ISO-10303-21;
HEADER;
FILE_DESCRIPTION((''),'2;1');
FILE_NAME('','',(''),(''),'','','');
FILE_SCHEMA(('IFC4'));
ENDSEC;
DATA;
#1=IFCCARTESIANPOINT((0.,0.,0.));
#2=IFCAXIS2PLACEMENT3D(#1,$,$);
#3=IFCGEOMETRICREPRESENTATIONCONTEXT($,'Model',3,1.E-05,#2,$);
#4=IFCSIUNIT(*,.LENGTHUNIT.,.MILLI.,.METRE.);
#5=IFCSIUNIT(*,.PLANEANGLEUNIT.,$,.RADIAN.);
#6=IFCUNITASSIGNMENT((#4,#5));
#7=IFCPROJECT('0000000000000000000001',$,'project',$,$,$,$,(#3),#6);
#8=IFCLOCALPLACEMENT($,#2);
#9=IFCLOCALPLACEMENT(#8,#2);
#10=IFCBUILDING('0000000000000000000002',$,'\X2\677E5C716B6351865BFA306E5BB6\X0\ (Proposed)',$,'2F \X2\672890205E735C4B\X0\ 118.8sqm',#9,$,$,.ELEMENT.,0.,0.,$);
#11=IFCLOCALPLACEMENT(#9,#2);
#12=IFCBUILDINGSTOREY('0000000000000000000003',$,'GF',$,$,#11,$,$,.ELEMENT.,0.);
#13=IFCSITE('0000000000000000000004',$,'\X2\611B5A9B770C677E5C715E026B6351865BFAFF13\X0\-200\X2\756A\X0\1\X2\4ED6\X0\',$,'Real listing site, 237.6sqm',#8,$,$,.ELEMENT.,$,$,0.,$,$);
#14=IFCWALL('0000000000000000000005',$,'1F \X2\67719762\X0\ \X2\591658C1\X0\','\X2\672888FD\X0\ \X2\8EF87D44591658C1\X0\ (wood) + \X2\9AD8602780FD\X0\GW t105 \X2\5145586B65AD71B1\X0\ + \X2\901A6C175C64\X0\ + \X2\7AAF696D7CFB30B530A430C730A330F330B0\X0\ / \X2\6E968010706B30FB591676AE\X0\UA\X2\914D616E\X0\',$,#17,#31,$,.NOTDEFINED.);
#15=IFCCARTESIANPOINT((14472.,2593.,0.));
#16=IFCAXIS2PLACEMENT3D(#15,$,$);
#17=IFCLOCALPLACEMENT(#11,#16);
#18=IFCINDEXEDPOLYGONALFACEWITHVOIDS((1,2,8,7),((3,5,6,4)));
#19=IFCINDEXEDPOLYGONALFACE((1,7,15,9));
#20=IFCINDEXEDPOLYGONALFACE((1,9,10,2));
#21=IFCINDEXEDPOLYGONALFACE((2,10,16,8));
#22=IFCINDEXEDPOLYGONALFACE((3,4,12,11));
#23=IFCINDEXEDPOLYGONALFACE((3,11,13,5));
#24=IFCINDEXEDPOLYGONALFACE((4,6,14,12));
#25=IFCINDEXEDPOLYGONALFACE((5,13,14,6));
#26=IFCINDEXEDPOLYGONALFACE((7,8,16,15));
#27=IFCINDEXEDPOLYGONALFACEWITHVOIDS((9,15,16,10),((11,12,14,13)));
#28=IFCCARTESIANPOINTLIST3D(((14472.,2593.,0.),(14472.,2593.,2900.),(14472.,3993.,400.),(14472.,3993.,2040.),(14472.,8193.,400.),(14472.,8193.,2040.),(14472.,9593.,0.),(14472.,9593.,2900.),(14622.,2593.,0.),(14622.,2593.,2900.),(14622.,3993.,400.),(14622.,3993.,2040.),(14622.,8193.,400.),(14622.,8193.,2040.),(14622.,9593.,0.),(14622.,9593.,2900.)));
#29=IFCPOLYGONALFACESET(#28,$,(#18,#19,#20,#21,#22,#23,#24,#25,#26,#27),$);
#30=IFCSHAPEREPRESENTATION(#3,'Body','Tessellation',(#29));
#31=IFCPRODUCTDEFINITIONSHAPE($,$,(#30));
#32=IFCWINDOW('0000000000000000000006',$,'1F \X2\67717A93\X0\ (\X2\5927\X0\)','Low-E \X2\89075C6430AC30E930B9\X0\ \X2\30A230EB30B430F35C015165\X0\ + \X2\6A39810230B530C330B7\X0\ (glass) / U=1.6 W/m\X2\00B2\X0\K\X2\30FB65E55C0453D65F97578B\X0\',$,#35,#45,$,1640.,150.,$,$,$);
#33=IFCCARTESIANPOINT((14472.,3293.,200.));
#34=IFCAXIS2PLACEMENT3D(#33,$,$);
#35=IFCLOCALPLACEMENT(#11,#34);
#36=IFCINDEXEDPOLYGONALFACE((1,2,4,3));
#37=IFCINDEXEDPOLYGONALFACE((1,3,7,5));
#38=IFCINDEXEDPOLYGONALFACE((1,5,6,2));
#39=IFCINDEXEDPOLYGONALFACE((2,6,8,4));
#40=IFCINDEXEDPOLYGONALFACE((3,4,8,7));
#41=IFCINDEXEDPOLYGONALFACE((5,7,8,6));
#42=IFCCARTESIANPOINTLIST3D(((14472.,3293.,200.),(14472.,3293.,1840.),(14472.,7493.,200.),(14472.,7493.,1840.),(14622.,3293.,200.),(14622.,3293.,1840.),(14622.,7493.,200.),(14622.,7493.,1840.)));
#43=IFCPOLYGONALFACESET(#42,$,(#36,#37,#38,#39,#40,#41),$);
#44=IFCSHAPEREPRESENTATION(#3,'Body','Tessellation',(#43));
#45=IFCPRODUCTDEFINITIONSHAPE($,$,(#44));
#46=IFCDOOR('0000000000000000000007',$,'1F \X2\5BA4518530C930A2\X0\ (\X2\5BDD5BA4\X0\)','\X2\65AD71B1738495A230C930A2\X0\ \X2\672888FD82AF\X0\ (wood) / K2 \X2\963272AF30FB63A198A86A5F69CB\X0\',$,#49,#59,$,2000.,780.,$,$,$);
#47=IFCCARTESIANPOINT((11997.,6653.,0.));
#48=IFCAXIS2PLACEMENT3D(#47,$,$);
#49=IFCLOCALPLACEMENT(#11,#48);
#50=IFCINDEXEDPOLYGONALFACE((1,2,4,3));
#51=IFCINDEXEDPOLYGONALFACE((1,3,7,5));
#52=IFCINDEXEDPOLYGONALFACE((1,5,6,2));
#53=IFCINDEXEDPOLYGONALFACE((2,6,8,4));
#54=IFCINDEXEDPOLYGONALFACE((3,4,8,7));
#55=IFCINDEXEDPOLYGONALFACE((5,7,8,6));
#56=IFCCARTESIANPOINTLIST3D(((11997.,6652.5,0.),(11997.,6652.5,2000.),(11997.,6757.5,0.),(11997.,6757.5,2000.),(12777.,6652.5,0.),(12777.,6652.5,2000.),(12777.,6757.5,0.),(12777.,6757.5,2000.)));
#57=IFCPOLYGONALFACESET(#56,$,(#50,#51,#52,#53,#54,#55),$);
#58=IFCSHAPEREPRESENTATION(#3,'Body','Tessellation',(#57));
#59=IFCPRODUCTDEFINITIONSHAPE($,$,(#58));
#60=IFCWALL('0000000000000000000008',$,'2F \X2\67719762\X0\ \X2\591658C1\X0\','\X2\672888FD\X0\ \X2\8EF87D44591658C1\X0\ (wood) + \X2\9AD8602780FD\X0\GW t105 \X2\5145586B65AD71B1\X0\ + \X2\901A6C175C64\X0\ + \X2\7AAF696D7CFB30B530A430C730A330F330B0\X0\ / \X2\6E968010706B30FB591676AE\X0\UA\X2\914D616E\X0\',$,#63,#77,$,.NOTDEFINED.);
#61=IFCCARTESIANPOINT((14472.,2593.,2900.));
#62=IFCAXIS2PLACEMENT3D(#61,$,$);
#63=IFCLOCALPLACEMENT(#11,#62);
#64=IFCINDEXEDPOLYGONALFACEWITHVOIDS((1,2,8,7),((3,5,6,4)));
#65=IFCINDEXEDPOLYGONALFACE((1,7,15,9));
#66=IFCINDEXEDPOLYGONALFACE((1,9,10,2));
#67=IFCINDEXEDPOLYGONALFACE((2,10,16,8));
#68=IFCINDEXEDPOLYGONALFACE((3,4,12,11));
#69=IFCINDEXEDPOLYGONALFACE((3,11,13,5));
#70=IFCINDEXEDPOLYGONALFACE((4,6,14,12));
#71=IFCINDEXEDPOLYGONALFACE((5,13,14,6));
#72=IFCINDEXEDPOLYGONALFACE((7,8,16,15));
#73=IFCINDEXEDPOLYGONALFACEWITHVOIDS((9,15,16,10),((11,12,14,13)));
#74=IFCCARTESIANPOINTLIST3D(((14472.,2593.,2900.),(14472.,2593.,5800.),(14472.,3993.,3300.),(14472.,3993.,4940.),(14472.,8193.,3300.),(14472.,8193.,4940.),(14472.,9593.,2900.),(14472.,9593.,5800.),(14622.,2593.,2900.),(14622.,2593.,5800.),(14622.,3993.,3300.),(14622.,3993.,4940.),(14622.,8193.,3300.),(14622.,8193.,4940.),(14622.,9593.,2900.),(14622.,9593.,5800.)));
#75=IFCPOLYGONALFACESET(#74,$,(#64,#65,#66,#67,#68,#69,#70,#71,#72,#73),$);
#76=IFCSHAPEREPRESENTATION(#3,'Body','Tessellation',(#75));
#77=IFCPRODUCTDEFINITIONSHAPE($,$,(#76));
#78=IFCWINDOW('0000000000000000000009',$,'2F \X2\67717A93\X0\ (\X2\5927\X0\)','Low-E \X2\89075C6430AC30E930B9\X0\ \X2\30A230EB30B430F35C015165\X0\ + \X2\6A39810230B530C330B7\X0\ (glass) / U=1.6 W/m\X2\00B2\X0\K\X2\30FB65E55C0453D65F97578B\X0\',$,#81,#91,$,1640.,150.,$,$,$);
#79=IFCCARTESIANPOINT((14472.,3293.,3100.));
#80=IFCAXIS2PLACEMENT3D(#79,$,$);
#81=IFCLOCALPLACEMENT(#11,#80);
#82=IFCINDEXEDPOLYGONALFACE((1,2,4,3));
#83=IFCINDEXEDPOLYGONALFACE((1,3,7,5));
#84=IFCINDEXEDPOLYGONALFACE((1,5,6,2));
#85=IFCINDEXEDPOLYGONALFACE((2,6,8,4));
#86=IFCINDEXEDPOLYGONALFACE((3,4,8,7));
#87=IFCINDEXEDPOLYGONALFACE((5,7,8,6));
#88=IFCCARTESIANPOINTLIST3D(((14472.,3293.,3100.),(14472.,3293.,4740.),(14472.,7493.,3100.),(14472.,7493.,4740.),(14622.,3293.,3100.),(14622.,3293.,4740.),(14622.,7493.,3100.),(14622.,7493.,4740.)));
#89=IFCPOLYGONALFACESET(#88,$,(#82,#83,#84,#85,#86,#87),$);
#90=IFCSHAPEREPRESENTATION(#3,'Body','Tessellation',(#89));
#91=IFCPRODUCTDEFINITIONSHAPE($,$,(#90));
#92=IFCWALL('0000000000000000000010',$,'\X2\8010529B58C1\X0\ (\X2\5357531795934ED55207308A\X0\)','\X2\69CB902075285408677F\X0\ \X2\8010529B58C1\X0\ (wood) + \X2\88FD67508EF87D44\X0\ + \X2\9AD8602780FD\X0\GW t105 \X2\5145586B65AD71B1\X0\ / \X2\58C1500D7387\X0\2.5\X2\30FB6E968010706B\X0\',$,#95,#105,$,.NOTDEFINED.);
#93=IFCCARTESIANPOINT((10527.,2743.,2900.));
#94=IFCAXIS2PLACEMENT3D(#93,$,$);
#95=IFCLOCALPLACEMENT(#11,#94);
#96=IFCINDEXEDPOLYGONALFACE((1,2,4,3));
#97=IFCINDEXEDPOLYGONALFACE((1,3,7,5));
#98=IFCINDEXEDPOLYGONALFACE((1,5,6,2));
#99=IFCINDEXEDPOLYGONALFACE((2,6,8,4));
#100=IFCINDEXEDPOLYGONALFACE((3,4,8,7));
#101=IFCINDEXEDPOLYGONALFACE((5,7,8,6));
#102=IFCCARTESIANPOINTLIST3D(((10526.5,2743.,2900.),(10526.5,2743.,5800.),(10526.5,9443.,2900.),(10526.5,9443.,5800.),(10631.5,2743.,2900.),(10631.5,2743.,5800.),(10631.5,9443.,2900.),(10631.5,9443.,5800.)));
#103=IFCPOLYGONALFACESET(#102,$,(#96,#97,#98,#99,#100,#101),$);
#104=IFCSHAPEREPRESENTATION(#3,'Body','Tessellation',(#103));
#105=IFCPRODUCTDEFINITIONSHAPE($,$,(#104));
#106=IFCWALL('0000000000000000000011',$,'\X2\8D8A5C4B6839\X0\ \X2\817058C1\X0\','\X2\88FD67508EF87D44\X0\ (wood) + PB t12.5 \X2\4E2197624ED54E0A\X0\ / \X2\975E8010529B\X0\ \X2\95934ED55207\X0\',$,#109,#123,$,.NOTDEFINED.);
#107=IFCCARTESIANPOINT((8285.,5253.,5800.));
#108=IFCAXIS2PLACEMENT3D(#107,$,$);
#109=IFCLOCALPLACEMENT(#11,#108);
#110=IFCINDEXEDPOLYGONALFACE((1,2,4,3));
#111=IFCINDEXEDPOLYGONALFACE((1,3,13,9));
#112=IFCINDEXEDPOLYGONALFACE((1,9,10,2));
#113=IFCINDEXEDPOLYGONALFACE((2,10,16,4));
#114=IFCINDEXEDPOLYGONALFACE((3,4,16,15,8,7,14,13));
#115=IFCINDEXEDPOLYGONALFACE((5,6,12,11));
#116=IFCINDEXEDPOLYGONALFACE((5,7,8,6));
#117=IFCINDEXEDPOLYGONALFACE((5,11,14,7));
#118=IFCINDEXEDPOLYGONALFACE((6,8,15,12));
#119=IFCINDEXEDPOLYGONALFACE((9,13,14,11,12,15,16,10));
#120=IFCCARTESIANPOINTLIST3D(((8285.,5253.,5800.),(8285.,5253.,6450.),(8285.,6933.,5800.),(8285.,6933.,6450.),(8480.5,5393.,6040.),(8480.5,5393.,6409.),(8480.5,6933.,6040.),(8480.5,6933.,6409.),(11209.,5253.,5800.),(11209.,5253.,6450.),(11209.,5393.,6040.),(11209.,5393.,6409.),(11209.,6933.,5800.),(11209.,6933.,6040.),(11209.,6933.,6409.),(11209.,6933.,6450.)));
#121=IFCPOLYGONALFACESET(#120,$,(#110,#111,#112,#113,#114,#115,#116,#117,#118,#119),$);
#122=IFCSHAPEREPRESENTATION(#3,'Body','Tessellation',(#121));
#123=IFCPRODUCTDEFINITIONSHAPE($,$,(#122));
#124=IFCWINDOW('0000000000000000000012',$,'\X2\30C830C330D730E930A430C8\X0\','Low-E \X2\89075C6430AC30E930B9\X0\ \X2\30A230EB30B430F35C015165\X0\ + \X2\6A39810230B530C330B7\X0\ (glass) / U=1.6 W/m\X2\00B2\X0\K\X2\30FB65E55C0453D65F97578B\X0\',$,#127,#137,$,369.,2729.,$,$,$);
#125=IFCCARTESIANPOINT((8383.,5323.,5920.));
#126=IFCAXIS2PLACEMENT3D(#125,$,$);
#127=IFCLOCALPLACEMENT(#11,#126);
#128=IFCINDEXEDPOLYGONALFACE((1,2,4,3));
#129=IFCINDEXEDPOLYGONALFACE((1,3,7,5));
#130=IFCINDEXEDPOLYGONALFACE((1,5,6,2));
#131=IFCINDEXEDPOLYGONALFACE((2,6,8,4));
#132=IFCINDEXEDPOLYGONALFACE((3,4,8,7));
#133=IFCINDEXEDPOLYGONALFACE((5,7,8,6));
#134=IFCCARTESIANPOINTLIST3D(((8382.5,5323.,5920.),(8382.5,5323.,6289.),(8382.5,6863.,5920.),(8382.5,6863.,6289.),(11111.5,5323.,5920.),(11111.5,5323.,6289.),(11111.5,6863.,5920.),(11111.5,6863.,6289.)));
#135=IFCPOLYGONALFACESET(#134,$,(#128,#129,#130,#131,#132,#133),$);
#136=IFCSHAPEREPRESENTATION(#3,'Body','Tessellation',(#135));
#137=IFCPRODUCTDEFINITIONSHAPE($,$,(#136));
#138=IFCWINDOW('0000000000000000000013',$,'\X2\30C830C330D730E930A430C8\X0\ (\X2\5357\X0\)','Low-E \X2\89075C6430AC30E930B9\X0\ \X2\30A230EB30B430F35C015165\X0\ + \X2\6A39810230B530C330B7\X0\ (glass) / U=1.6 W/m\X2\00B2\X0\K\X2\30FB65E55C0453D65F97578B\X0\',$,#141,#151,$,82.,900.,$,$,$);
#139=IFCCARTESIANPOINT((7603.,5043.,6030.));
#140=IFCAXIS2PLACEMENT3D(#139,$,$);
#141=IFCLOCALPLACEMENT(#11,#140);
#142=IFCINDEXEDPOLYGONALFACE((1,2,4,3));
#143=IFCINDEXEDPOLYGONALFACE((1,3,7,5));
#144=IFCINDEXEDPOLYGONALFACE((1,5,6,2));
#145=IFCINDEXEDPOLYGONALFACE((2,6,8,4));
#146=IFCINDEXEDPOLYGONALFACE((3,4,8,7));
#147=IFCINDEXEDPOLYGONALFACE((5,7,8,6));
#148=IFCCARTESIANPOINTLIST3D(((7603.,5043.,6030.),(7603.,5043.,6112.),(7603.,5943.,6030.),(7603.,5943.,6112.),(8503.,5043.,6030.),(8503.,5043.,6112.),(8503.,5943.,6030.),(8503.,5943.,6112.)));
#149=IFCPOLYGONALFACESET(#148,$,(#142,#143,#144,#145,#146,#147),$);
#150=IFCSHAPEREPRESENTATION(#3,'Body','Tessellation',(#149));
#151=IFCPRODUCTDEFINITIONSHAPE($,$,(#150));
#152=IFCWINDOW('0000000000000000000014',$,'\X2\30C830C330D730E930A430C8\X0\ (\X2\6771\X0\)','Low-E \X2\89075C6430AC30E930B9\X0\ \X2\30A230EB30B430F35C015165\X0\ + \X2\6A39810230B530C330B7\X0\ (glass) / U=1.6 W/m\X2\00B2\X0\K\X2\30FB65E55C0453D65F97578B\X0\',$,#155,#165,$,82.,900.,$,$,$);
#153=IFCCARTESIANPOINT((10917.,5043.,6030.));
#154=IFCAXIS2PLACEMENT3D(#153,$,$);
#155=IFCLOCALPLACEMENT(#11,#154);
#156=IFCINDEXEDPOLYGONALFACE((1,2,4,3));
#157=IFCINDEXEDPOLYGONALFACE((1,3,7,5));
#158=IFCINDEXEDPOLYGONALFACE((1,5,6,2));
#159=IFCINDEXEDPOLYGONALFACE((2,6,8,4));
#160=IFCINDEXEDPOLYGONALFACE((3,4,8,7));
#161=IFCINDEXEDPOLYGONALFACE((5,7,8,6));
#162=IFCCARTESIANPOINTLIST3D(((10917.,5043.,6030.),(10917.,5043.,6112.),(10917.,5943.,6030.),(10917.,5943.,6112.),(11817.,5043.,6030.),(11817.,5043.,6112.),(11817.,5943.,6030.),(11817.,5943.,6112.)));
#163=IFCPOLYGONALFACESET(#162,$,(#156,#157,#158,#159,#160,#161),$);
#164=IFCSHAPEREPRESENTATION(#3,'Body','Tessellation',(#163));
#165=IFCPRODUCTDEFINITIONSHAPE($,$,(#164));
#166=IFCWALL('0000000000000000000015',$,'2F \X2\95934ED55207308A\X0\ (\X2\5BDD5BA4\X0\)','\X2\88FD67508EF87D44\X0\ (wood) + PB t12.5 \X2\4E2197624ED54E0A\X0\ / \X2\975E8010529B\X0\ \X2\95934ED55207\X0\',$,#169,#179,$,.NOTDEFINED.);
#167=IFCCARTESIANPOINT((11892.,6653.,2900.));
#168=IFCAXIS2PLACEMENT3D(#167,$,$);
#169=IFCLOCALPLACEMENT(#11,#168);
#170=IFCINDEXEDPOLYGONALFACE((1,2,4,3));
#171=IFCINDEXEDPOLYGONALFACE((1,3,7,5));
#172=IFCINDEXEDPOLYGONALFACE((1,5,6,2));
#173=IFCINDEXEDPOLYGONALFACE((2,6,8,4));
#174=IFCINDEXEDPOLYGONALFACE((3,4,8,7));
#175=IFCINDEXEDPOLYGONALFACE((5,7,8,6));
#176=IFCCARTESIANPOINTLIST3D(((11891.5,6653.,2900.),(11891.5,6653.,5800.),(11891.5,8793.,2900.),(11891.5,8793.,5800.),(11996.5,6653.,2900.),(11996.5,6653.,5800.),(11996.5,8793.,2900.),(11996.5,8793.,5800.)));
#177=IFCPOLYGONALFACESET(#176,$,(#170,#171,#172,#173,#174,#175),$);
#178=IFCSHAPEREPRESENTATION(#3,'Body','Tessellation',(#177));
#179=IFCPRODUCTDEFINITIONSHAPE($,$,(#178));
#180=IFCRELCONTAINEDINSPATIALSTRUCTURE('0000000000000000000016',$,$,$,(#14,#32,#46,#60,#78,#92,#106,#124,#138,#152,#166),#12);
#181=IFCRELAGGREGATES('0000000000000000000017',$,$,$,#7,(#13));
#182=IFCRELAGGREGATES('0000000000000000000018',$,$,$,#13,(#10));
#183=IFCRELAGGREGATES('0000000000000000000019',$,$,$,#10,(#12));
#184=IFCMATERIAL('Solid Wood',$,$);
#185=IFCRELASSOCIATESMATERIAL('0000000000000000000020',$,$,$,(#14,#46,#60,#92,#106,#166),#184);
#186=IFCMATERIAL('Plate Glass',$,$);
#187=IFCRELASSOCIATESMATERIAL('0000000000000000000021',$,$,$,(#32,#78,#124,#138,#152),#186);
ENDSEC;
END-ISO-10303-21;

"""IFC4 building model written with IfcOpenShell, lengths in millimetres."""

from ifc_helpers import new_model, si_unit, frame, frame_2d, origin, place, context, project, spatial, rectangle, extrude, material, element, fill, save


model = new_model("IFC4")

# Units and contexts
model_context = context("Model", 3, precision=1e-05, world=origin())
ifc_project = project(units=[si_unit("LENGTHUNIT", "METRE", prefix="MILLI"), si_unit("PLANEANGLEUNIT", "RADIAN")], contexts=[model_context])

# Site, building, storey
site_placement = place(None, origin())
site = spatial("IfcSite", under=ifc_project, at=site_placement, Name="愛媛県松山市正円寺３-200番1他", ObjectType="Real listing site, 237.6sqm", CompositionType="ELEMENT", RefElevation=0.0)
building_placement = place(site_placement, origin())
building = spatial("IfcBuilding", under=site, at=building_placement, Name="松山正円寺の家 (Proposed)", ObjectType="2F 木造平屋 118.8sqm", CompositionType="ELEMENT", ElevationOfRefHeight=0.0, ElevationOfTerrain=0.0)
storey_placement = place(building_placement, origin())
storey = spatial("IfcBuildingStorey", under=building, at=storey_placement, Name="GF", CompositionType="ELEMENT", Elevation=0.0)

# Wall, opening, window
ifc_material_1 = material(Name="Solid Wood")
wall_1_placement = place(storey_placement, frame((14472.0, 2593.0, 0.0)))
wall_1 = element("IfcWall", 1, at=wall_1_placement, inside=storey, material=ifc_material_1, Name="1F 東面 外壁", Description="木製 軸組外壁 (wood) + 高性能GW t105 充填断熱 + 通気層 + 窯業系サイディング / 準耐火・外皮UA配慮", PredefinedType="NOTDEFINED", context=model_context, shape_type="SweptSolid", body=[
    extrude(rectangle(XDim=150.0, YDim=7000.0, at=frame_2d((75.0, 3500.0))), frame((14472.0, 2593.0, 0.0)), (0.0, 0.0, 1.0), 2900.0),
])
opening_1_placement = place(storey_placement, frame((14472.0, 3293.0, 200.0)))
opening_1 = element("IfcOpeningElement", 2, at=opening_1_placement, cuts=wall_1, PredefinedType="NOTDEFINED", context=model_context, shape_type="SweptSolid", body=[
    extrude(rectangle(XDim=150.0, YDim=4200.0, at=frame_2d((75.0, 2100.0))), frame((14472.0, 3293.0, 200.0)), (0.0, 0.0, 1.0), 1640.0),
])
ifc_material_2 = material(Name="Plate Glass")
window_1_placement = place(storey_placement, frame((14472.0, 3293.0, 200.0)))
window_1 = element("IfcWindow", 3, at=window_1_placement, inside=storey, material=ifc_material_2, Name="1F 東窓 (大)", Description="Low-E 複層ガラス アルゴン封入 + 樹脂サッシ (glass) / U=1.6 W/m²K・日射取得型", OverallHeight=1640.0, OverallWidth=150.0, context=model_context, shape_type="SweptSolid", body=[
    extrude(rectangle(XDim=150.0, YDim=4200.0, at=frame_2d((75.0, 2100.0))), frame((14472.0, 3293.0, 200.0)), (0.0, 0.0, 1.0), 1640.0),
])
fill(opening_1, window_1)

# Door
door_1_placement = place(storey_placement, frame((11997.0, 6653.0, 0.0)))
element("IfcDoor", 4, at=door_1_placement, inside=storey, material=ifc_material_1, Name="1F 室内ドア (寝室)", Description="断熱玄関ドア 木製芯 (wood) / K2 防犯・採風機構", OverallHeight=2000.0, OverallWidth=780.0, context=model_context, shape_type="SweptSolid", body=[
    extrude(rectangle(XDim=780.0, YDim=105.0, at=frame_2d((390.0, 52.0))), frame((11997.0, 6653.0, 0.0)), (0.0, 0.0, 1.0), 2000.0),
])

# Wall, opening, window
wall_2_placement = place(storey_placement, frame((14472.0, 2593.0, 2900.0)))
wall_2 = element("IfcWall", 5, at=wall_2_placement, inside=storey, material=ifc_material_1, Name="2F 東面 外壁", Description="木製 軸組外壁 (wood) + 高性能GW t105 充填断熱 + 通気層 + 窯業系サイディング / 準耐火・外皮UA配慮", PredefinedType="NOTDEFINED", context=model_context, shape_type="SweptSolid", body=[
    extrude(rectangle(XDim=150.0, YDim=7000.0, at=frame_2d((75.0, 3500.0))), frame((14472.0, 2593.0, 2900.0)), (0.0, 0.0, 1.0), 2900.0),
])
opening_2_placement = place(storey_placement, frame((14472.0, 3293.0, 3100.0)))
opening_2 = element("IfcOpeningElement", 6, at=opening_2_placement, cuts=wall_2, PredefinedType="NOTDEFINED", context=model_context, shape_type="SweptSolid", body=[
    extrude(rectangle(XDim=150.0, YDim=4200.0, at=frame_2d((75.0, 2100.0))), frame((14472.0, 3293.0, 3100.0)), (0.0, 0.0, 1.0), 1640.0),
])
window_2_placement = place(storey_placement, frame((14472.0, 3293.0, 3100.0)))
window_2 = element("IfcWindow", 7, at=window_2_placement, inside=storey, material=ifc_material_2, Name="2F 東窓 (大)", Description="Low-E 複層ガラス アルゴン封入 + 樹脂サッシ (glass) / U=1.6 W/m²K・日射取得型", OverallHeight=1640.0, OverallWidth=150.0, context=model_context, shape_type="SweptSolid", body=[
    extrude(rectangle(XDim=150.0, YDim=4200.0, at=frame_2d((75.0, 2100.0))), frame((14472.0, 3293.0, 3100.0)), (0.0, 0.0, 1.0), 1640.0),
])
fill(opening_2, window_2)

# Wall
wall_3_placement = place(storey_placement, frame((10527.0, 2743.0, 2900.0)))
element("IfcWall", 8, at=wall_3_placement, inside=storey, material=ifc_material_1, Name="耐力壁 (南北間仕切り)", Description="構造用合板 耐力壁 (wood) + 製材軸組 + 高性能GW t105 充填断熱 / 壁倍率2.5・準耐火", PredefinedType="NOTDEFINED", context=model_context, shape_type="SweptSolid", body=[
    extrude(rectangle(XDim=105.0, YDim=6700.0, at=frame_2d((52.0, 3350.0))), frame((10527.0, 2743.0, 2900.0)), (0.0, 0.0, 1.0), 2900.0),
])

# Wall, openings, windows
wall_4_placement = place(storey_placement, frame((8285.0, 5253.0, 5800.0)))
wall_4 = element("IfcWall", 9, at=wall_4_placement, inside=storey, material=ifc_material_1, Name="越屋根 腰壁", Description="製材軸組 (wood) + PB t12.5 両面仕上 / 非耐力 間仕切", PredefinedType="NOTDEFINED", context=model_context, shape_type="SweptSolid", body=[
    extrude(rectangle(XDim=2924.0, YDim=1680.0, at=frame_2d((1462.0, 840.0))), frame((8285.0, 5253.0, 5800.0)), (0.0, 0.0, 1.0), 650.0),
])
opening_3_placement = place(storey_placement, frame((8383.0, 5323.0, 5920.0)))
opening_3 = element("IfcOpeningElement", 10, at=opening_3_placement, cuts=wall_4, PredefinedType="NOTDEFINED", context=model_context, shape_type="SweptSolid", body=[
    extrude(rectangle(XDim=2729.0, YDim=1540.0, at=frame_2d((1364.0, 770.0))), frame((8383.0, 5323.0, 5920.0)), (0.0, 0.0, 1.0), 369.0),
])
opening_4_placement = place(storey_placement, frame((7603.0, 5043.0, 6030.0)))
opening_4 = element("IfcOpeningElement", 11, at=opening_4_placement, cuts=wall_4, PredefinedType="NOTDEFINED", context=model_context, shape_type="SweptSolid", body=[
    extrude(rectangle(XDim=900.0, YDim=900.0, at=frame_2d((450.0, 450.0))), frame((7603.0, 5043.0, 6030.0)), (0.0, 0.0, 1.0), 82.0),
])
opening_5_placement = place(storey_placement, frame((10917.0, 5043.0, 6030.0)))
opening_5 = element("IfcOpeningElement", 12, at=opening_5_placement, cuts=wall_4, PredefinedType="NOTDEFINED", context=model_context, shape_type="SweptSolid", body=[
    extrude(rectangle(XDim=900.0, YDim=900.0, at=frame_2d((450.0, 450.0))), frame((10917.0, 5043.0, 6030.0)), (0.0, 0.0, 1.0), 82.0),
])
window_3_placement = place(storey_placement, frame((8383.0, 5323.0, 5920.0)))
window_3 = element("IfcWindow", 13, at=window_3_placement, inside=storey, material=ifc_material_2, Name="トップライト", Description="Low-E 複層ガラス アルゴン封入 + 樹脂サッシ (glass) / U=1.6 W/m²K・日射取得型", OverallHeight=369.0, OverallWidth=2729.0, context=model_context, shape_type="SweptSolid", body=[
    extrude(rectangle(XDim=2729.0, YDim=1540.0, at=frame_2d((1364.0, 770.0))), frame((8383.0, 5323.0, 5920.0)), (0.0, 0.0, 1.0), 369.0),
])
fill(opening_3, window_3)
window_4_placement = place(storey_placement, frame((7603.0, 5043.0, 6030.0)))
window_4 = element("IfcWindow", 14, at=window_4_placement, inside=storey, material=ifc_material_2, Name="トップライト (南)", Description="Low-E 複層ガラス アルゴン封入 + 樹脂サッシ (glass) / U=1.6 W/m²K・日射取得型", OverallHeight=82.0, OverallWidth=900.0, context=model_context, shape_type="SweptSolid", body=[
    extrude(rectangle(XDim=900.0, YDim=900.0, at=frame_2d((450.0, 450.0))), frame((7603.0, 5043.0, 6030.0)), (0.0, 0.0, 1.0), 82.0),
])
fill(opening_4, window_4)
window_5_placement = place(storey_placement, frame((10917.0, 5043.0, 6030.0)))
window_5 = element("IfcWindow", 15, at=window_5_placement, inside=storey, material=ifc_material_2, Name="トップライト (東)", Description="Low-E 複層ガラス アルゴン封入 + 樹脂サッシ (glass) / U=1.6 W/m²K・日射取得型", OverallHeight=82.0, OverallWidth=900.0, context=model_context, shape_type="SweptSolid", body=[
    extrude(rectangle(XDim=900.0, YDim=900.0, at=frame_2d((450.0, 450.0))), frame((10917.0, 5043.0, 6030.0)), (0.0, 0.0, 1.0), 82.0),
])
fill(opening_5, window_5)

# Wall
wall_5_placement = place(storey_placement, frame((11892.0, 6653.0, 2900.0)))
element("IfcWall", 16, at=wall_5_placement, inside=storey, material=ifc_material_1, Name="2F 間仕切り (寝室)", Description="製材軸組 (wood) + PB t12.5 両面仕上 / 非耐力 間仕切", PredefinedType="NOTDEFINED", context=model_context, shape_type="SweptSolid", body=[
    extrude(rectangle(XDim=105.0, YDim=2140.0, at=frame_2d((52.0, 1070.0))), frame((11892.0, 6653.0, 2900.0)), (0.0, 0.0, 1.0), 2900.0),
])

save(model, "model.ifc")
